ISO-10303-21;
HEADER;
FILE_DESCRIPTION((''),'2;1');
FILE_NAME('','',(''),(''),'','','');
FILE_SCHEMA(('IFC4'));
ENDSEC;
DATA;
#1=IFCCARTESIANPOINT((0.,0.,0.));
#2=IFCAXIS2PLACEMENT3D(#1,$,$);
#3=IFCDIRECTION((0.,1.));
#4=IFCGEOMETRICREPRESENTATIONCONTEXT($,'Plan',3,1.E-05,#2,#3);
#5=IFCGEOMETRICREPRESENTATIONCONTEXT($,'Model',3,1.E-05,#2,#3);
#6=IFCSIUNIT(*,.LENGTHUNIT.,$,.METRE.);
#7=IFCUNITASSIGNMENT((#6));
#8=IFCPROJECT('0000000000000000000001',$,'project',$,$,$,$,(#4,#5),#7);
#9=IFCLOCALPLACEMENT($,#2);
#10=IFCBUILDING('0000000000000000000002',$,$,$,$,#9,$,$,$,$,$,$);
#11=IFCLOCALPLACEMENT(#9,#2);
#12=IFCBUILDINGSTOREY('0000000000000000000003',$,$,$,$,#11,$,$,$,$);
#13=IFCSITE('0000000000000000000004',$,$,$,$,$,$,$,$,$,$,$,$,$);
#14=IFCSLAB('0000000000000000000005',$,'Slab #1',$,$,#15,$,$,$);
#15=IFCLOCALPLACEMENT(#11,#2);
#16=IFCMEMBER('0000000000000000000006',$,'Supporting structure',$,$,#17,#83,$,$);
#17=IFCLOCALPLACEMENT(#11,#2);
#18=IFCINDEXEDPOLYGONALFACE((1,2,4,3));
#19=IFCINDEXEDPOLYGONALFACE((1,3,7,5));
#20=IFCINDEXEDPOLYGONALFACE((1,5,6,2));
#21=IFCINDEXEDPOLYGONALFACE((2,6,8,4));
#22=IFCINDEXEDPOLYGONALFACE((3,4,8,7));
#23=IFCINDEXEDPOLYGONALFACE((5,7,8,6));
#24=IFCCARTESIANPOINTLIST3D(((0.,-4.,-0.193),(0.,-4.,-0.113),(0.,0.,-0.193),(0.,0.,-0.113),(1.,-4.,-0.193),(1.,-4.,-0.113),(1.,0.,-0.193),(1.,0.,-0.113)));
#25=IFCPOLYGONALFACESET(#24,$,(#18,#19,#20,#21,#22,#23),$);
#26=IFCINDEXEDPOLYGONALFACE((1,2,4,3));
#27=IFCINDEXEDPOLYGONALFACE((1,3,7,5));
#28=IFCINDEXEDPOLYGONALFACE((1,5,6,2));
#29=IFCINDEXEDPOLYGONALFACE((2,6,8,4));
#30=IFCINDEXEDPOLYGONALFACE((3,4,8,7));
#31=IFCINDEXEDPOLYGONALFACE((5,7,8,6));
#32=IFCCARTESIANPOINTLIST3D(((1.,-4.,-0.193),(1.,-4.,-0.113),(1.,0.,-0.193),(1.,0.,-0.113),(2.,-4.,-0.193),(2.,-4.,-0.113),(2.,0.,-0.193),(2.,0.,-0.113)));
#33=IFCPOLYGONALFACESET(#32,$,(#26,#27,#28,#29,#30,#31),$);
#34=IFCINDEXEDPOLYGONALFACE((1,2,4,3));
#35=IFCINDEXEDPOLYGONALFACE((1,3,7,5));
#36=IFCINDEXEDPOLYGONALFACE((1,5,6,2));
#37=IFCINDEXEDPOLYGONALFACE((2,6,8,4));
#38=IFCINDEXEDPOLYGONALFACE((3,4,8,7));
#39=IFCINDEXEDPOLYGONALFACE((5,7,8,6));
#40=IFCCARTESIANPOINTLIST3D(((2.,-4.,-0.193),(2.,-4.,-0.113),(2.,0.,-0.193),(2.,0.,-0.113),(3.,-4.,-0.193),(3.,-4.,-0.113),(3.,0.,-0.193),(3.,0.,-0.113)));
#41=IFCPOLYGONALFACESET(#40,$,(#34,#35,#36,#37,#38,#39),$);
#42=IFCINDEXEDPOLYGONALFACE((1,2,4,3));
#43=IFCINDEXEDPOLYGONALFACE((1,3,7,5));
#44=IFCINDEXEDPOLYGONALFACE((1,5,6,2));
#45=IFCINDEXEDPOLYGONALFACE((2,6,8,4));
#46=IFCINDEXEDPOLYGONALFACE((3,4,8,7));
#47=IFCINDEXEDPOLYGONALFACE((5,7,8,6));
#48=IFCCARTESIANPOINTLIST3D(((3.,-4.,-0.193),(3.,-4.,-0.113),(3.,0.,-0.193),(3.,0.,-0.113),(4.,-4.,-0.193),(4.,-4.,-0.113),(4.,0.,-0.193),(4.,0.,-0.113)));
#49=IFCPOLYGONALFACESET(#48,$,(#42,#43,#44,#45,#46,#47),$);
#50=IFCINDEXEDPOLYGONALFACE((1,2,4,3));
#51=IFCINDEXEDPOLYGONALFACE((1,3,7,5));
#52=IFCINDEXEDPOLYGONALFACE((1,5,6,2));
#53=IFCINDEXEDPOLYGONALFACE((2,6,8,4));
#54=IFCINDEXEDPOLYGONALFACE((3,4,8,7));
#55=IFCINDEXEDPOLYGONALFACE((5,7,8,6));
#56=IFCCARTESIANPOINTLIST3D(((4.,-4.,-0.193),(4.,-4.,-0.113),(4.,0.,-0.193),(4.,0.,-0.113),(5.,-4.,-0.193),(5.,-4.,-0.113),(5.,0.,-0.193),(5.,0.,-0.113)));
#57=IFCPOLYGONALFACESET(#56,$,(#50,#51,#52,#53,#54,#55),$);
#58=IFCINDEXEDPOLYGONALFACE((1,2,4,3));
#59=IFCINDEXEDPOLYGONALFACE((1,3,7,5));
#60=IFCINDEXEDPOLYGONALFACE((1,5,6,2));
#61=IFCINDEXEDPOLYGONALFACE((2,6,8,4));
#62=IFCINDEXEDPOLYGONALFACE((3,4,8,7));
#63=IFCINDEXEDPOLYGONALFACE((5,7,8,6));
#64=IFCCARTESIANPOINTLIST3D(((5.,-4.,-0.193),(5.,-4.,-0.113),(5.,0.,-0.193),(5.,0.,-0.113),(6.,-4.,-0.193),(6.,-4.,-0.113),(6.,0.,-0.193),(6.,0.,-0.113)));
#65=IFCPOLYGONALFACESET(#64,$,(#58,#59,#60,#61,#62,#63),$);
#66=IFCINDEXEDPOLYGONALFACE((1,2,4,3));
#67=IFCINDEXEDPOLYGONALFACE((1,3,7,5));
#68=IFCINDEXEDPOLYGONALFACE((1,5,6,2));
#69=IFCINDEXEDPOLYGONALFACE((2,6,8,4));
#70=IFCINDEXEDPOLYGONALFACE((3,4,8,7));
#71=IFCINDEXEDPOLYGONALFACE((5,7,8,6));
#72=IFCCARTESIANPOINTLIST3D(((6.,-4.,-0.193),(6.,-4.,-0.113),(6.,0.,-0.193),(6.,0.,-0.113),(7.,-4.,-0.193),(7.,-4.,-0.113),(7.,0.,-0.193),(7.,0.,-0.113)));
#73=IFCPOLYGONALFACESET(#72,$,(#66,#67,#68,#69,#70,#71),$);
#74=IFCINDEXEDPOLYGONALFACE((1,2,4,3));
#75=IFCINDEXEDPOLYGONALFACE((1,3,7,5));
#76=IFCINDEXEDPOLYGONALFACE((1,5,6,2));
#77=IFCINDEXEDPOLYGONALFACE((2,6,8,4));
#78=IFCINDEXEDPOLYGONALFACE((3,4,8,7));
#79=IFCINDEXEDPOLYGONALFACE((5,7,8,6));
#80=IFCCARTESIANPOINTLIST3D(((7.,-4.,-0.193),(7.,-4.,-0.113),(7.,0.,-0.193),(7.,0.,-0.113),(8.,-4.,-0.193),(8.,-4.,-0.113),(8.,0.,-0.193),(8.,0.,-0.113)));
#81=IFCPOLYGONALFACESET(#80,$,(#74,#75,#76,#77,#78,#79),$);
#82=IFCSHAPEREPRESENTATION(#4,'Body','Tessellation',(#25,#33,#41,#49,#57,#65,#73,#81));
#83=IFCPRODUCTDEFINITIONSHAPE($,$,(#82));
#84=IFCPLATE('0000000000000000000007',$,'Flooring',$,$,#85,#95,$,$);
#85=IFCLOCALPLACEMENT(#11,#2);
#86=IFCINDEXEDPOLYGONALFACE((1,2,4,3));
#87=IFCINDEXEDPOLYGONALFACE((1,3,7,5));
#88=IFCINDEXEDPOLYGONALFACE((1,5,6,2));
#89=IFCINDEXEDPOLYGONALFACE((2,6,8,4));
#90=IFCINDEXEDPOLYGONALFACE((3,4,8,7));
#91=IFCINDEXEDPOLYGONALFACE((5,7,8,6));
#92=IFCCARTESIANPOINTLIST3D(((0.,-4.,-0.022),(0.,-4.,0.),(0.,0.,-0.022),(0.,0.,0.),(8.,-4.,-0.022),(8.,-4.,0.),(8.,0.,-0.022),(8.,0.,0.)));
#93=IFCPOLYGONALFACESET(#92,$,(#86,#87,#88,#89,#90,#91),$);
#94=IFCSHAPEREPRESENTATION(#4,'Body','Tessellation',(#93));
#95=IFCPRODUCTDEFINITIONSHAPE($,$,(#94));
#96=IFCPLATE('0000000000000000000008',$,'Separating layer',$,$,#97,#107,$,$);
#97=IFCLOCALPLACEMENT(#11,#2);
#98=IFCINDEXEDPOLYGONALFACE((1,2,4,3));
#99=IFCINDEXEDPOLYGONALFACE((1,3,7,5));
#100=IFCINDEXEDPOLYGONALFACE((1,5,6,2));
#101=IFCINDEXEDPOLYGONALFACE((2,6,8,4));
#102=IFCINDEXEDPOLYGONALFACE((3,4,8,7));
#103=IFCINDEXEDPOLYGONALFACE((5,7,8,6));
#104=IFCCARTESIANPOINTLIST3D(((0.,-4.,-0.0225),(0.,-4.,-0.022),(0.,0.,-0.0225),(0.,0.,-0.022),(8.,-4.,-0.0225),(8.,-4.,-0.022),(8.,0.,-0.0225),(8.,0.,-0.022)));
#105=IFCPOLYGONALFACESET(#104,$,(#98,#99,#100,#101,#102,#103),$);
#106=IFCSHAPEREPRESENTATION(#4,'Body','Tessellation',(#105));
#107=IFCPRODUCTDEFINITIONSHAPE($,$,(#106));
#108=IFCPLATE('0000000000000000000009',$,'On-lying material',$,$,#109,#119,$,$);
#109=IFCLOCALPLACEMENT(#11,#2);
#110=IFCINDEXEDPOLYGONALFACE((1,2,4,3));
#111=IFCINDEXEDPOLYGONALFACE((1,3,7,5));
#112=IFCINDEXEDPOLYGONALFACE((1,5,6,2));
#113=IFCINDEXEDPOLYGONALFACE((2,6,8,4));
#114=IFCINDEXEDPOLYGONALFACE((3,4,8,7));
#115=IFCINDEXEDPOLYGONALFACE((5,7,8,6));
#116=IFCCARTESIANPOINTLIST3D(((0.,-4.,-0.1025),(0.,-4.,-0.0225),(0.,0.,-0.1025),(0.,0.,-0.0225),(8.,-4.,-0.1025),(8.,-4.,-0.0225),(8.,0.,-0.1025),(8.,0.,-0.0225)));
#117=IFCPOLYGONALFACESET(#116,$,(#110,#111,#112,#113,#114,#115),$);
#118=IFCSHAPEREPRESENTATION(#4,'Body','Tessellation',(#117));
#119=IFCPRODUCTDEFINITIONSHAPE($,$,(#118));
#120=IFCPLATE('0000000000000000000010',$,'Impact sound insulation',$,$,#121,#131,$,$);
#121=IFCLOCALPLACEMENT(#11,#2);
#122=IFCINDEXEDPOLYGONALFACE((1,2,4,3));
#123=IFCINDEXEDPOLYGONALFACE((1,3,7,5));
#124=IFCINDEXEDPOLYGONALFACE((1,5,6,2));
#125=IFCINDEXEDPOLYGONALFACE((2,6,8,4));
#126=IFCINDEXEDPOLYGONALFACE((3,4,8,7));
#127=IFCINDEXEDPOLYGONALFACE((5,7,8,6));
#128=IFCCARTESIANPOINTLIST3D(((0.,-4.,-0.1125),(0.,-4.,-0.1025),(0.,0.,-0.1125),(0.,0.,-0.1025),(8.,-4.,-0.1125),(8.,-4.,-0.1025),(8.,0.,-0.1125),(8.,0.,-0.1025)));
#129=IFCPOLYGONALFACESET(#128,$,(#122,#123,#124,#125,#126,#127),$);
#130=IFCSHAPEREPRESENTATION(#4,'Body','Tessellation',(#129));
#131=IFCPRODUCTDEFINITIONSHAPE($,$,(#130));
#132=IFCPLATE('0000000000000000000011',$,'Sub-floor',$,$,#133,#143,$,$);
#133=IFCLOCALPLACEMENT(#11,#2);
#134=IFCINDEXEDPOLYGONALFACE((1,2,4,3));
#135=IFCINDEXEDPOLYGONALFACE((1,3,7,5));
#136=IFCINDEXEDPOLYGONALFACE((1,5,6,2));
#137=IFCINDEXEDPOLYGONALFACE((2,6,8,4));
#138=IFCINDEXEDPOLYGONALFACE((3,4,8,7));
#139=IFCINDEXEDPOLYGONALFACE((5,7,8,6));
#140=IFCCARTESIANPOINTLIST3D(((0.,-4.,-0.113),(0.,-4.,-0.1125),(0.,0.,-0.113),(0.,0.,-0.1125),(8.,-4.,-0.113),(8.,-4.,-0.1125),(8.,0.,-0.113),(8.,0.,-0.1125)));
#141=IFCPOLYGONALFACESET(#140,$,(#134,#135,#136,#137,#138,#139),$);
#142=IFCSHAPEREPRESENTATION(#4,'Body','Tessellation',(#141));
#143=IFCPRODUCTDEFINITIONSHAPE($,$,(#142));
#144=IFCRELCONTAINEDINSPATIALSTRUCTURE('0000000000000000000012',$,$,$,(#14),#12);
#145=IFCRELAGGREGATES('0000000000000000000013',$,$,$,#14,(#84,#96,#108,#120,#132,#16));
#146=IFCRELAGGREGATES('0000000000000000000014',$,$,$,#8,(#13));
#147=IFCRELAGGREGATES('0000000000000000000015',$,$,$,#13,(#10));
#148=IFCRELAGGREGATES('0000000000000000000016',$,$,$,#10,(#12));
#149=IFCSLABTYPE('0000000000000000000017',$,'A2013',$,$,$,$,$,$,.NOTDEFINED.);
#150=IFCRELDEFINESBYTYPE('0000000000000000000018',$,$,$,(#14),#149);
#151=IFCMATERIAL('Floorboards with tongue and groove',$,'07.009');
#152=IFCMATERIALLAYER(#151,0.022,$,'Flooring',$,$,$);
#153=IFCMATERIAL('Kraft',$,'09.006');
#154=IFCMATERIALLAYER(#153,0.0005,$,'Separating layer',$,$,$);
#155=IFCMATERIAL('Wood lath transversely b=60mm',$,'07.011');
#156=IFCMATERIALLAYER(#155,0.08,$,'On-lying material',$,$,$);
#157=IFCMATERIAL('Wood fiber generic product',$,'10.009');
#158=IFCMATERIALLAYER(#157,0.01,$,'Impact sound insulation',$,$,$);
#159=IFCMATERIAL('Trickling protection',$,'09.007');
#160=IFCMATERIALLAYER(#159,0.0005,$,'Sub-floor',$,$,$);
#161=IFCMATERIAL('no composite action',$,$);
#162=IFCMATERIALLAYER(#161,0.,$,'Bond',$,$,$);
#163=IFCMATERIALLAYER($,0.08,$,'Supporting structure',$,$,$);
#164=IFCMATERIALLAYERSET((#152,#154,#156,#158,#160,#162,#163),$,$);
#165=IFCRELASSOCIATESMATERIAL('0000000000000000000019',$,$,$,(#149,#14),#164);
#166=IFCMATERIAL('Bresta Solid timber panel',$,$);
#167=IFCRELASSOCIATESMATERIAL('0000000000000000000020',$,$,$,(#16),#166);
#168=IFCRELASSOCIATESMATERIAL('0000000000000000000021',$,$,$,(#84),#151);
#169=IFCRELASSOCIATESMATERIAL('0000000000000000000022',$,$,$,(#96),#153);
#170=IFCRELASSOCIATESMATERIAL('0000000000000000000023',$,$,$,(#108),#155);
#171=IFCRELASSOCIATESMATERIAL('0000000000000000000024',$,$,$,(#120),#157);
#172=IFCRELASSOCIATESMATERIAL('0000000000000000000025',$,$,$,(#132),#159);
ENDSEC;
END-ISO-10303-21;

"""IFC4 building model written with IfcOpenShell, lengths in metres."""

from ifc_helpers import new_model, si_unit, direction, frame, frame_2d, origin, origin_with_axes, place, context, project, spatial, rectangle, extrude, material, layer, layer_set, type_object, element, aggregate, save


model = new_model("IFC4")

# Units and contexts
plan_context = context("Plan", 3, precision=1e-05, world=origin(), true_north=direction((0.0, 1.0)))
model_context = context("Model", 3, precision=1e-05, world=origin(), true_north=direction((0.0, 1.0)))
ifc_project = project(units=[si_unit("LENGTHUNIT", "METRE")], contexts=[plan_context, model_context])

# Site, building, storey
site = spatial("IfcSite", under=ifc_project)
building_placement = place(None, origin())
building = spatial("IfcBuilding", under=site, at=building_placement)
storey_placement = place(building_placement, origin())
storey = spatial("IfcBuildingStorey", under=building, at=storey_placement)

# Slab, member, plates
ifc_material_1 = material(Name="Floorboards with tongue and groove", Category="07.009")
ifc_layer_1 = layer(ifc_material_1, 0.022, Name="Flooring")
ifc_material_2 = material(Name="Kraft", Category="09.006")
ifc_layer_2 = layer(ifc_material_2, 0.0005, Name="Separating layer")
ifc_material_3 = material(Name="Wood lath transversely b=60mm", Category="07.011")
ifc_layer_3 = layer(ifc_material_3, 0.08, Name="On-lying material")
ifc_material_4 = material(Name="Wood fiber generic product", Category="10.009")
ifc_layer_4 = layer(ifc_material_4, 0.01, Name="Impact sound insulation")
ifc_material_5 = material(Name="Trickling protection", Category="09.007")
ifc_layer_5 = layer(ifc_material_5, 0.0005, Name="Sub-floor")
ifc_material_6 = material(Name="no composite action")
ifc_layer_6 = layer(ifc_material_6, 0.0, Name="Bond")
ifc_layer_7 = layer(None, 0.08, Name="Supporting structure")
ifc_layer_set = layer_set([ifc_layer_1, ifc_layer_2, ifc_layer_3, ifc_layer_4, ifc_layer_5, ifc_layer_6, ifc_layer_7])
slab_type = type_object("IfcSlabType", Name="A2013", PredefinedType="NOTDEFINED", material=ifc_layer_set)
slab_placement = place(None, frame((0.0, 0.0, 0.0), z_axis=(0.0, 0.0, -1.0), x_axis=(1.0, 0.0, 0.0)))
slab = element("IfcSlab", 1, at=slab_placement, inside=storey, type_object=slab_type, material=ifc_layer_set, Name="Slab #1")
ifc_material_7 = material(Name="Bresta Solid timber panel")
member_placement = place(slab_placement, origin())
member = element("IfcMember", 2, at=member_placement, material=ifc_material_7, Name="Supporting structure", context=plan_context, shape_type="SweptSolid", body=[
    extrude(rectangle(XDim=1.0, YDim=0.08, at=frame_2d((0.5, 0.04), x_axis=(1.0, 0.0))), frame((0.0, 4.0, 0.113), z_axis=(0.0, -1.0, 0.0), x_axis=(1.0, 0.0, 0.0)), (0.0, 0.0, 1.0), 4.0),
    extrude(rectangle(XDim=1.0, YDim=0.08, at=frame_2d((0.5, 0.04), x_axis=(1.0, 0.0))), frame((1.0, 4.0, 0.113), z_axis=(0.0, -1.0, 0.0), x_axis=(1.0, 0.0, 0.0)), (0.0, 0.0, 1.0), 4.0),
    extrude(rectangle(XDim=1.0, YDim=0.08, at=frame_2d((0.5, 0.04), x_axis=(1.0, 0.0))), frame((2.0, 4.0, 0.113), z_axis=(0.0, -1.0, 0.0), x_axis=(1.0, 0.0, 0.0)), (0.0, 0.0, 1.0), 4.0),
    extrude(rectangle(XDim=1.0, YDim=0.08, at=frame_2d((0.5, 0.04), x_axis=(1.0, 0.0))), frame((3.0, 4.0, 0.113), z_axis=(0.0, -1.0, 0.0), x_axis=(1.0, 0.0, 0.0)), (0.0, 0.0, 1.0), 4.0),
    extrude(rectangle(XDim=1.0, YDim=0.08, at=frame_2d((0.5, 0.04), x_axis=(1.0, 0.0))), frame((4.0, 4.0, 0.113), z_axis=(0.0, -1.0, 0.0), x_axis=(1.0, 0.0, 0.0)), (0.0, 0.0, 1.0), 4.0),
    extrude(rectangle(XDim=1.0, YDim=0.08, at=frame_2d((0.5, 0.04), x_axis=(1.0, 0.0))), frame((5.0, 4.0, 0.113), z_axis=(0.0, -1.0, 0.0), x_axis=(1.0, 0.0, 0.0)), (0.0, 0.0, 1.0), 4.0),
    extrude(rectangle(XDim=1.0, YDim=0.08, at=frame_2d((0.5, 0.04), x_axis=(1.0, 0.0))), frame((6.0, 4.0, 0.113), z_axis=(0.0, -1.0, 0.0), x_axis=(1.0, 0.0, 0.0)), (0.0, 0.0, 1.0), 4.0),
    extrude(rectangle(XDim=1.0, YDim=0.08, at=frame_2d((0.5, 0.04), x_axis=(1.0, 0.0))), frame((7.0, 4.0, 0.113), z_axis=(0.0, -1.0, 0.0), x_axis=(1.0, 0.0, 0.0)), (0.0, 0.0, 1.0), 4.0),
])
plate_1_placement = place(slab_placement, origin())
plate_1 = element("IfcPlate", 3, at=plate_1_placement, material=ifc_material_1, Name="Flooring", context=plan_context, shape_type="SweptSolid", body=[
    extrude(rectangle(XDim=8.0, YDim=4.0, at=frame_2d((4.0, 2.0), x_axis=(1.0, 0.0))), origin_with_axes(), (0.0, 0.0, 1.0), 0.022),
])
plate_2_placement = place(slab_placement, origin())
plate_2 = element("IfcPlate", 4, at=plate_2_placement, material=ifc_material_2, Name="Separating layer", context=plan_context, shape_type="SweptSolid", body=[
    extrude(rectangle(XDim=8.0, YDim=4.0, at=frame_2d((4.0, 2.0), x_axis=(1.0, 0.0))), frame((0.0, 0.0, 0.022), z_axis=(0.0, 0.0, 1.0), x_axis=(1.0, 0.0, 0.0)), (0.0, 0.0, 1.0), 0.0005),
])
plate_3_placement = place(slab_placement, origin())
plate_3 = element("IfcPlate", 5, at=plate_3_placement, material=ifc_material_3, Name="On-lying material", context=plan_context, shape_type="SweptSolid", body=[
    extrude(rectangle(XDim=8.0, YDim=4.0, at=frame_2d((4.0, 2.0), x_axis=(1.0, 0.0))), frame((0.0, 0.0, 0.0225), z_axis=(0.0, 0.0, 1.0), x_axis=(1.0, 0.0, 0.0)), (0.0, 0.0, 1.0), 0.08),
])
plate_4_placement = place(slab_placement, origin())
plate_4 = element("IfcPlate", 6, at=plate_4_placement, material=ifc_material_4, Name="Impact sound insulation", context=plan_context, shape_type="SweptSolid", body=[
    extrude(rectangle(XDim=8.0, YDim=4.0, at=frame_2d((4.0, 2.0), x_axis=(1.0, 0.0))), frame((0.0, 0.0, 0.1025), z_axis=(0.0, 0.0, 1.0), x_axis=(1.0, 0.0, 0.0)), (0.0, 0.0, 1.0), 0.01),
])
plate_5_placement = place(slab_placement, origin())
plate_5 = element("IfcPlate", 7, at=plate_5_placement, material=ifc_material_5, Name="Sub-floor", context=plan_context, shape_type="SweptSolid", body=[
    extrude(rectangle(XDim=8.0, YDim=4.0, at=frame_2d((4.0, 2.0), x_axis=(1.0, 0.0))), frame((0.0, 0.0, 0.1125), z_axis=(0.0, 0.0, 1.0), x_axis=(1.0, 0.0, 0.0)), (0.0, 0.0, 1.0), 0.0005),
])
aggregate(slab, [plate_1, plate_2, plate_3, plate_4, plate_5, member])

save(model, "model.ifc")
